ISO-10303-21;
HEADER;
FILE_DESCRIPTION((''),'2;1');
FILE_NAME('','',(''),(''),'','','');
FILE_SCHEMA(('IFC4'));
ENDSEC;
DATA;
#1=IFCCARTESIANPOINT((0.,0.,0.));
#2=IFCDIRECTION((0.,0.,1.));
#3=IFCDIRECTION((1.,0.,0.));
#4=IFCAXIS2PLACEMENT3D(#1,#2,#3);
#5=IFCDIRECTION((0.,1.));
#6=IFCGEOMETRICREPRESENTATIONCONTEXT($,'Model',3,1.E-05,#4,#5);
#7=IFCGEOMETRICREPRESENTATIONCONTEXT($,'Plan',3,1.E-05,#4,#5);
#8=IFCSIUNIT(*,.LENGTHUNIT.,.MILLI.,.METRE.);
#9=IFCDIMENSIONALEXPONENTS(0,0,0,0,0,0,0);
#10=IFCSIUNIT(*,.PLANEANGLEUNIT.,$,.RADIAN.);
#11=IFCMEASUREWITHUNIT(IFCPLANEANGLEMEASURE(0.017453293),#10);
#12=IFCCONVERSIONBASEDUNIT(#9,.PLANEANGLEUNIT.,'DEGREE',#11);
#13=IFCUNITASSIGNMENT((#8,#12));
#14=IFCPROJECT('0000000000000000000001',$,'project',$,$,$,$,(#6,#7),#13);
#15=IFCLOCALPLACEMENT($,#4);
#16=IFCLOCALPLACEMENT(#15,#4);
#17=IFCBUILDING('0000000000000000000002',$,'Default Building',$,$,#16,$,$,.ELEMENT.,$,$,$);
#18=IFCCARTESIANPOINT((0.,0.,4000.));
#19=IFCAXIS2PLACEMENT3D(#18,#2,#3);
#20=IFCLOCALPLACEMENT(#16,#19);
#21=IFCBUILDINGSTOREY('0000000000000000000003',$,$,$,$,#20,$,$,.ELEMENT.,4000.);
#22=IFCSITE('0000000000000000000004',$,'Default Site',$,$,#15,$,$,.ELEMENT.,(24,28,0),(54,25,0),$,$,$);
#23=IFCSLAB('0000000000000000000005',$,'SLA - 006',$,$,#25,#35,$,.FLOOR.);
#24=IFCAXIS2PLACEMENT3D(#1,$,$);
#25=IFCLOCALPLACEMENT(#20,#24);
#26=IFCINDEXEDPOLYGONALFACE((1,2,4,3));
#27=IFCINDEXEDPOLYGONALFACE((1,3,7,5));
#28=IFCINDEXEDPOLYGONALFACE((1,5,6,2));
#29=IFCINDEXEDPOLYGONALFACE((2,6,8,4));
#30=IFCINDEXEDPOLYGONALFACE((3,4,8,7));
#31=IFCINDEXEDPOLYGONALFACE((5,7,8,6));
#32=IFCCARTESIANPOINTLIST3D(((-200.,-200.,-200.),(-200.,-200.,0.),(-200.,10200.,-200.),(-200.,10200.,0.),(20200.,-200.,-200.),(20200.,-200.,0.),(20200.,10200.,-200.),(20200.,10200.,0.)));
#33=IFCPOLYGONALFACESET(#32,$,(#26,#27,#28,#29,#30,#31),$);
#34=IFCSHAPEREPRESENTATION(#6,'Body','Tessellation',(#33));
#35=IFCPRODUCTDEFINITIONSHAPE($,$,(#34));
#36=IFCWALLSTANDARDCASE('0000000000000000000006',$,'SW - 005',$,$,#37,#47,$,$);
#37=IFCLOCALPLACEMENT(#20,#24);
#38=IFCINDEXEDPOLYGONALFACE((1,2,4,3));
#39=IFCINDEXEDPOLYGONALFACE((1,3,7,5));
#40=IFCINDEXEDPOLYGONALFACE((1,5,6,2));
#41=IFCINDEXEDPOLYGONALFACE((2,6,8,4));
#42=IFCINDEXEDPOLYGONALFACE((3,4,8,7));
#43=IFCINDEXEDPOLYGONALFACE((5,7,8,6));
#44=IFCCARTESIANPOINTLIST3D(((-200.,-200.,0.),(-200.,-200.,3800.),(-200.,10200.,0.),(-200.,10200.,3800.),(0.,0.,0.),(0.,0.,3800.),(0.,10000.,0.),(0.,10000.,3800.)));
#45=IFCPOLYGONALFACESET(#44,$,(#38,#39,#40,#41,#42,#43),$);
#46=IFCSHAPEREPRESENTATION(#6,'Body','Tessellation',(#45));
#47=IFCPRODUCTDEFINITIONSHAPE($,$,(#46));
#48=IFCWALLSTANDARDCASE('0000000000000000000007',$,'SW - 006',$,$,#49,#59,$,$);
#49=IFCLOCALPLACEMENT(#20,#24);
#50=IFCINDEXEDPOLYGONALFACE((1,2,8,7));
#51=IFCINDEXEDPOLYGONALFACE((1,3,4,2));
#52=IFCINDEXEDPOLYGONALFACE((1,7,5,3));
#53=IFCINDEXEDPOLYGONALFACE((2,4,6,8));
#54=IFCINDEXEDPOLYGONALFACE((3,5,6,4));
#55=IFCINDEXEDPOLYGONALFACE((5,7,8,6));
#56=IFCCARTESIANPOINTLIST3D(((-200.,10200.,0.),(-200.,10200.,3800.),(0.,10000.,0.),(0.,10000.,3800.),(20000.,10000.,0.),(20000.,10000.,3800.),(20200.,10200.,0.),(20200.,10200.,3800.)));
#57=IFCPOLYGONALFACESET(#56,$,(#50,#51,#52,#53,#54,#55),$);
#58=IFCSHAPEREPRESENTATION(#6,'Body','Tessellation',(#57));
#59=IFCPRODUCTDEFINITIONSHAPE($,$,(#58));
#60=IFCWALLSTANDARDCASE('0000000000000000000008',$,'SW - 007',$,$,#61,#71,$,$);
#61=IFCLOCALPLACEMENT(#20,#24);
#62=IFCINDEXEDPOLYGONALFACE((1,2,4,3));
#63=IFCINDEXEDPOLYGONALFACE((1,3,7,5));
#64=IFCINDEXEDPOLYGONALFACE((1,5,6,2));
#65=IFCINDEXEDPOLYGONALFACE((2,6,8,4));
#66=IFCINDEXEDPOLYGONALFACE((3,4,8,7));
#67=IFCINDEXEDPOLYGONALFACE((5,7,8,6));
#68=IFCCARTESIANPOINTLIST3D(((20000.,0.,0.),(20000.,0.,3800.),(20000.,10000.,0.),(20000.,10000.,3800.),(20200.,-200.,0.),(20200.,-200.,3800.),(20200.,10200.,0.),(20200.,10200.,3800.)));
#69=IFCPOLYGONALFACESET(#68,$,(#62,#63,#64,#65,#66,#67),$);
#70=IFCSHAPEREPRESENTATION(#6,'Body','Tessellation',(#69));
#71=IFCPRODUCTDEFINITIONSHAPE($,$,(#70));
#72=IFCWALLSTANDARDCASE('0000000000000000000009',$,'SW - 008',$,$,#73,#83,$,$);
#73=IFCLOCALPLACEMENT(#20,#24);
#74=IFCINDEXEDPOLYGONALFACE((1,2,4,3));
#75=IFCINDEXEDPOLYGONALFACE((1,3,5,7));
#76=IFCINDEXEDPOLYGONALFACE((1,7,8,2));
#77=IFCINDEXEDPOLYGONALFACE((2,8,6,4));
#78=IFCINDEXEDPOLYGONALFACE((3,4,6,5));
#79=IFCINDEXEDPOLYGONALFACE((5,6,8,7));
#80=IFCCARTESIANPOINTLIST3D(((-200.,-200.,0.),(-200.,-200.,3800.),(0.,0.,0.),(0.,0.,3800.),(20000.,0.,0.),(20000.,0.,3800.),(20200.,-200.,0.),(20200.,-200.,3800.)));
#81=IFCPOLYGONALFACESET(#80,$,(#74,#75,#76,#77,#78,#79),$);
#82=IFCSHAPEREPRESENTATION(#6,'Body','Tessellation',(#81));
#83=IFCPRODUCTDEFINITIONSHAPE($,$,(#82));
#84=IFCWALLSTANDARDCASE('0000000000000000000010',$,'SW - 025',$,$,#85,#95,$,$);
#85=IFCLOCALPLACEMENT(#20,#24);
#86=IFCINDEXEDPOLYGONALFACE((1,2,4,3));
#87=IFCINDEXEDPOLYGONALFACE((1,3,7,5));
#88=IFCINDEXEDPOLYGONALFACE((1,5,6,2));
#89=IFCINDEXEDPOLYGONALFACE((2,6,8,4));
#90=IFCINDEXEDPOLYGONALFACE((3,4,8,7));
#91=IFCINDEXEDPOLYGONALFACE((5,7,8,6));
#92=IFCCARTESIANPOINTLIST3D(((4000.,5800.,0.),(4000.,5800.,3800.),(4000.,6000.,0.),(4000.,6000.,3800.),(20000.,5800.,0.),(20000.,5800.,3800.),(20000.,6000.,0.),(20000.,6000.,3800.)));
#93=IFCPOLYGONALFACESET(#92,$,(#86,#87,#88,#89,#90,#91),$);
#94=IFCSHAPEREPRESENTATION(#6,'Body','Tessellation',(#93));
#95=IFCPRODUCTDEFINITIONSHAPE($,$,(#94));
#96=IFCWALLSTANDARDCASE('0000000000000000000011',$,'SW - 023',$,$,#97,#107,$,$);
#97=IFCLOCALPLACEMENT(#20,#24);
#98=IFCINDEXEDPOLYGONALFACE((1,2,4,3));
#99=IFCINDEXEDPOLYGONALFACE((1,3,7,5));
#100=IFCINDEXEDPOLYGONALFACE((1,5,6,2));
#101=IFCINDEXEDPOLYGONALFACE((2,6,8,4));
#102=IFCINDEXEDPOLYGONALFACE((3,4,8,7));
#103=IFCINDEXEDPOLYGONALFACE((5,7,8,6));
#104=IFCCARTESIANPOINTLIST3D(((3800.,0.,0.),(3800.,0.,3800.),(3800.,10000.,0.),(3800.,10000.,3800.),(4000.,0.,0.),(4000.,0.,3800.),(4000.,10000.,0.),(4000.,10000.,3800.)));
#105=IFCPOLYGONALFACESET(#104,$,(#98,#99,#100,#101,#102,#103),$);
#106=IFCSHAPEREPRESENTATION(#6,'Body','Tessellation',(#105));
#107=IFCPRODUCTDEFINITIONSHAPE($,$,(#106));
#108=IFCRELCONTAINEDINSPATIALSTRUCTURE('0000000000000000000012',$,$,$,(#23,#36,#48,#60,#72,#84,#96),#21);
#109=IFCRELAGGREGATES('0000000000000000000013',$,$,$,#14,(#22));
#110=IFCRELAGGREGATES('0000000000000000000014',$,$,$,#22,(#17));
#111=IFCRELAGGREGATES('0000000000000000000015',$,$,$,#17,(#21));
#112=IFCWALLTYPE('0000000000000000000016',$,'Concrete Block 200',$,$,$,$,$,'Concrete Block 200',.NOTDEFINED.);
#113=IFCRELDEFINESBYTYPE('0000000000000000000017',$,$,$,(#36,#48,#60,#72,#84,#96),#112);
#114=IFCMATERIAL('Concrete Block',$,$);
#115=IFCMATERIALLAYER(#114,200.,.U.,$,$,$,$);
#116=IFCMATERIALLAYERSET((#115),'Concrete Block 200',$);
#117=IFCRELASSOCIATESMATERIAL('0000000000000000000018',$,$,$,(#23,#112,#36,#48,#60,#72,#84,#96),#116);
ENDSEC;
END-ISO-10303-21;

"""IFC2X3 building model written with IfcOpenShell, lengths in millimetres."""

from ifc_helpers import new_model, entity, si_unit, converted_unit, direction, frame, origin_with_axes, place, context, project, spatial, polyline, outline, extrude, material, layer, layer_set, layer_usage, type_object, element, save


model = new_model("IFC2X3")

# Units and contexts
model_context = context("Model", 3, precision=1e-05, world=origin_with_axes(), true_north=direction((0.0, 1.0)))
plan_context = context("Plan", 3, precision=1e-05, world=origin_with_axes(), true_north=direction((0.0, 1.0)))
ifc_project = project(units=[si_unit("LENGTHUNIT", "METRE", prefix="MILLI"), converted_unit("PLANEANGLEUNIT", "DEGREE", entity("IfcPlaneAngleMeasure", 0.017453293), si_unit("PLANEANGLEUNIT", "RADIAN"), dimensions=[0, 0, 0, 0, 0, 0, 0])], contexts=[model_context, plan_context])

# Site, building, storey
site_placement = place(None, origin_with_axes())
site = spatial("IfcSite", under=ifc_project, at=site_placement, Name="Default Site", CompositionType="ELEMENT", RefLatitude=(24, 28, 0), RefLongitude=(54, 25, 0))
building_placement = place(site_placement, origin_with_axes())
building = spatial("IfcBuilding", under=site, at=building_placement, Name="Default Building", CompositionType="ELEMENT")
storey_placement = place(building_placement, frame((0.0, 0.0, 4000.0), z_axis=(0.0, 0.0, 1.0), x_axis=(1.0, 0.0, 0.0)))
storey = spatial("IfcBuildingStorey", under=building, at=storey_placement, CompositionType="ELEMENT", Elevation=4000.0)

# Slab
ifc_material = material(Name="Concrete Block")
ifc_layer = layer(ifc_material, 200.0, ventilated="UNKNOWN")
ifc_layer_set = layer_set([ifc_layer], Name="Concrete Block 200")
ifc_layer_usage_1 = layer_usage(ifc_layer_set, "AXIS3", "NEGATIVE", 200.0)
slab_placement = place(storey_placement, frame((-200.0, 10200.0, -200.0), z_axis=(0.0, 0.0, 1.0), x_axis=(1.0, 0.0, 0.0)))
element("IfcSlab", 1, at=slab_placement, inside=storey, material=ifc_layer_usage_1, Name="SLA - 006", PredefinedType="FLOOR", context=model_context, shape_type="SweptSolid", body=[
    extrude(outline(polyline([(0.0, 0.0), (20400.0, 0.0), (20400.0, -10400.0), (0.0, -10400.0), (0.0, 0.0)])), origin_with_axes(), (0.0, 0.0, 1.0), 200.0),
])

# Walls
ifc_layer_usage_2 = layer_usage(ifc_layer_set, "AXIS2", "POSITIVE", 0.0)
wall_type = type_object("IfcWallType", Name="Concrete Block 200", ElementType="Concrete Block 200", PredefinedType="NOTDEFINED", material=ifc_layer_set)
wall_1_placement = place(storey_placement, frame((0.0, 0.0, 0.0), z_axis=(0.0, 0.0, 1.0), x_axis=(0.0, 1.0, 0.0)))
element("IfcWallStandardCase", 2, at=wall_1_placement, inside=storey, type_object=wall_type, material=ifc_layer_usage_2, Name="SW - 005", context=model_context, shape_type="SweptSolid", body=[
    extrude(outline(polyline([(0.0, 0.0), (10000.0, 0.0), (10200.0, 200.0), (-200.0, 200.0), (0.0, 0.0)])), origin_with_axes(), (0.0, 0.0, 1.0), 3800.0),
])
ifc_layer_usage_3 = layer_usage(ifc_layer_set, "AXIS2", "POSITIVE", 0.0)
wall_2_placement = place(storey_placement, frame((0.0, 10000.0, 0.0), z_axis=(0.0, 0.0, 1.0), x_axis=(1.0, 0.0, 0.0)))
element("IfcWallStandardCase", 3, at=wall_2_placement, inside=storey, type_object=wall_type, material=ifc_layer_usage_3, Name="SW - 006", context=model_context, shape_type="SweptSolid", body=[
    extrude(outline(polyline([(0.0, 0.0), (20000.0, 0.0), (20200.0, 200.0), (-200.0, 200.0), (0.0, 0.0)])), origin_with_axes(), (0.0, 0.0, 1.0), 3800.0),
])
ifc_layer_usage_4 = layer_usage(ifc_layer_set, "AXIS2", "POSITIVE", 0.0)
wall_3_placement = place(storey_placement, frame((20000.0, 10000.0, 0.0), z_axis=(0.0, 0.0, 1.0), x_axis=(0.0, -1.0, 0.0)))
element("IfcWallStandardCase", 4, at=wall_3_placement, inside=storey, type_object=wall_type, material=ifc_layer_usage_4, Name="SW - 007", context=model_context, shape_type="SweptSolid", body=[
    extrude(outline(polyline([(0.0, 0.0), (10000.0, 0.0), (10200.0, 200.0), (-200.0, 200.0), (0.0, 0.0)])), origin_with_axes(), (0.0, 0.0, 1.0), 3800.0),
])
ifc_layer_usage_5 = layer_usage(ifc_layer_set, "AXIS2", "POSITIVE", 0.0)
wall_4_placement = place(storey_placement, frame((20000.0, 0.0, 0.0), z_axis=(0.0, 0.0, 1.0), x_axis=(-1.0, 0.0, 0.0)))
element("IfcWallStandardCase", 5, at=wall_4_placement, inside=storey, type_object=wall_type, material=ifc_layer_usage_5, Name="SW - 008", context=model_context, shape_type="SweptSolid", body=[
    extrude(outline(polyline([(0.0, 0.0), (20000.0, 0.0), (20200.0, 200.0), (-200.0, 200.0), (0.0, 0.0)])), origin_with_axes(), (0.0, 0.0, 1.0), 3800.0),
])
ifc_layer_usage_6 = layer_usage(ifc_layer_set, "AXIS2", "NEGATIVE", 0.0)
wall_5_placement = place(storey_placement, frame((3800.0, 6000.0, 0.0), z_axis=(0.0, 0.0, 1.0), x_axis=(1.0, 0.0, 0.0)))
element("IfcWallStandardCase", 6, at=wall_5_placement, inside=storey, type_object=wall_type, material=ifc_layer_usage_6, Name="SW - 025", context=model_context, shape_type="SweptSolid", body=[
    extrude(outline(polyline([(200.0, -200.0), (16200.0, -200.0), (16200.0, 0.0), (200.0, 0.0), (200.0, -200.0)])), origin_with_axes(), (0.0, 0.0, 1.0), 3800.0),
])
ifc_layer_usage_7 = layer_usage(ifc_layer_set, "AXIS2", "POSITIVE", 0.0)
wall_6_placement = place(storey_placement, frame((3800.0, 10000.0, 0.0), z_axis=(0.0, 0.0, 1.0), x_axis=(0.0, -1.0, 0.0)))
element("IfcWallStandardCase", 7, at=wall_6_placement, inside=storey, type_object=wall_type, material=ifc_layer_usage_7, Name="SW - 023", context=model_context, shape_type="SweptSolid", body=[
    extrude(outline(polyline([(0.0, 0.0), (10000.0, 0.0), (10000.0, 200.0), (0.0, 200.0), (0.0, 0.0)])), origin_with_axes(), (0.0, 0.0, 1.0), 3800.0),
])

save(model, "model.ifc")
